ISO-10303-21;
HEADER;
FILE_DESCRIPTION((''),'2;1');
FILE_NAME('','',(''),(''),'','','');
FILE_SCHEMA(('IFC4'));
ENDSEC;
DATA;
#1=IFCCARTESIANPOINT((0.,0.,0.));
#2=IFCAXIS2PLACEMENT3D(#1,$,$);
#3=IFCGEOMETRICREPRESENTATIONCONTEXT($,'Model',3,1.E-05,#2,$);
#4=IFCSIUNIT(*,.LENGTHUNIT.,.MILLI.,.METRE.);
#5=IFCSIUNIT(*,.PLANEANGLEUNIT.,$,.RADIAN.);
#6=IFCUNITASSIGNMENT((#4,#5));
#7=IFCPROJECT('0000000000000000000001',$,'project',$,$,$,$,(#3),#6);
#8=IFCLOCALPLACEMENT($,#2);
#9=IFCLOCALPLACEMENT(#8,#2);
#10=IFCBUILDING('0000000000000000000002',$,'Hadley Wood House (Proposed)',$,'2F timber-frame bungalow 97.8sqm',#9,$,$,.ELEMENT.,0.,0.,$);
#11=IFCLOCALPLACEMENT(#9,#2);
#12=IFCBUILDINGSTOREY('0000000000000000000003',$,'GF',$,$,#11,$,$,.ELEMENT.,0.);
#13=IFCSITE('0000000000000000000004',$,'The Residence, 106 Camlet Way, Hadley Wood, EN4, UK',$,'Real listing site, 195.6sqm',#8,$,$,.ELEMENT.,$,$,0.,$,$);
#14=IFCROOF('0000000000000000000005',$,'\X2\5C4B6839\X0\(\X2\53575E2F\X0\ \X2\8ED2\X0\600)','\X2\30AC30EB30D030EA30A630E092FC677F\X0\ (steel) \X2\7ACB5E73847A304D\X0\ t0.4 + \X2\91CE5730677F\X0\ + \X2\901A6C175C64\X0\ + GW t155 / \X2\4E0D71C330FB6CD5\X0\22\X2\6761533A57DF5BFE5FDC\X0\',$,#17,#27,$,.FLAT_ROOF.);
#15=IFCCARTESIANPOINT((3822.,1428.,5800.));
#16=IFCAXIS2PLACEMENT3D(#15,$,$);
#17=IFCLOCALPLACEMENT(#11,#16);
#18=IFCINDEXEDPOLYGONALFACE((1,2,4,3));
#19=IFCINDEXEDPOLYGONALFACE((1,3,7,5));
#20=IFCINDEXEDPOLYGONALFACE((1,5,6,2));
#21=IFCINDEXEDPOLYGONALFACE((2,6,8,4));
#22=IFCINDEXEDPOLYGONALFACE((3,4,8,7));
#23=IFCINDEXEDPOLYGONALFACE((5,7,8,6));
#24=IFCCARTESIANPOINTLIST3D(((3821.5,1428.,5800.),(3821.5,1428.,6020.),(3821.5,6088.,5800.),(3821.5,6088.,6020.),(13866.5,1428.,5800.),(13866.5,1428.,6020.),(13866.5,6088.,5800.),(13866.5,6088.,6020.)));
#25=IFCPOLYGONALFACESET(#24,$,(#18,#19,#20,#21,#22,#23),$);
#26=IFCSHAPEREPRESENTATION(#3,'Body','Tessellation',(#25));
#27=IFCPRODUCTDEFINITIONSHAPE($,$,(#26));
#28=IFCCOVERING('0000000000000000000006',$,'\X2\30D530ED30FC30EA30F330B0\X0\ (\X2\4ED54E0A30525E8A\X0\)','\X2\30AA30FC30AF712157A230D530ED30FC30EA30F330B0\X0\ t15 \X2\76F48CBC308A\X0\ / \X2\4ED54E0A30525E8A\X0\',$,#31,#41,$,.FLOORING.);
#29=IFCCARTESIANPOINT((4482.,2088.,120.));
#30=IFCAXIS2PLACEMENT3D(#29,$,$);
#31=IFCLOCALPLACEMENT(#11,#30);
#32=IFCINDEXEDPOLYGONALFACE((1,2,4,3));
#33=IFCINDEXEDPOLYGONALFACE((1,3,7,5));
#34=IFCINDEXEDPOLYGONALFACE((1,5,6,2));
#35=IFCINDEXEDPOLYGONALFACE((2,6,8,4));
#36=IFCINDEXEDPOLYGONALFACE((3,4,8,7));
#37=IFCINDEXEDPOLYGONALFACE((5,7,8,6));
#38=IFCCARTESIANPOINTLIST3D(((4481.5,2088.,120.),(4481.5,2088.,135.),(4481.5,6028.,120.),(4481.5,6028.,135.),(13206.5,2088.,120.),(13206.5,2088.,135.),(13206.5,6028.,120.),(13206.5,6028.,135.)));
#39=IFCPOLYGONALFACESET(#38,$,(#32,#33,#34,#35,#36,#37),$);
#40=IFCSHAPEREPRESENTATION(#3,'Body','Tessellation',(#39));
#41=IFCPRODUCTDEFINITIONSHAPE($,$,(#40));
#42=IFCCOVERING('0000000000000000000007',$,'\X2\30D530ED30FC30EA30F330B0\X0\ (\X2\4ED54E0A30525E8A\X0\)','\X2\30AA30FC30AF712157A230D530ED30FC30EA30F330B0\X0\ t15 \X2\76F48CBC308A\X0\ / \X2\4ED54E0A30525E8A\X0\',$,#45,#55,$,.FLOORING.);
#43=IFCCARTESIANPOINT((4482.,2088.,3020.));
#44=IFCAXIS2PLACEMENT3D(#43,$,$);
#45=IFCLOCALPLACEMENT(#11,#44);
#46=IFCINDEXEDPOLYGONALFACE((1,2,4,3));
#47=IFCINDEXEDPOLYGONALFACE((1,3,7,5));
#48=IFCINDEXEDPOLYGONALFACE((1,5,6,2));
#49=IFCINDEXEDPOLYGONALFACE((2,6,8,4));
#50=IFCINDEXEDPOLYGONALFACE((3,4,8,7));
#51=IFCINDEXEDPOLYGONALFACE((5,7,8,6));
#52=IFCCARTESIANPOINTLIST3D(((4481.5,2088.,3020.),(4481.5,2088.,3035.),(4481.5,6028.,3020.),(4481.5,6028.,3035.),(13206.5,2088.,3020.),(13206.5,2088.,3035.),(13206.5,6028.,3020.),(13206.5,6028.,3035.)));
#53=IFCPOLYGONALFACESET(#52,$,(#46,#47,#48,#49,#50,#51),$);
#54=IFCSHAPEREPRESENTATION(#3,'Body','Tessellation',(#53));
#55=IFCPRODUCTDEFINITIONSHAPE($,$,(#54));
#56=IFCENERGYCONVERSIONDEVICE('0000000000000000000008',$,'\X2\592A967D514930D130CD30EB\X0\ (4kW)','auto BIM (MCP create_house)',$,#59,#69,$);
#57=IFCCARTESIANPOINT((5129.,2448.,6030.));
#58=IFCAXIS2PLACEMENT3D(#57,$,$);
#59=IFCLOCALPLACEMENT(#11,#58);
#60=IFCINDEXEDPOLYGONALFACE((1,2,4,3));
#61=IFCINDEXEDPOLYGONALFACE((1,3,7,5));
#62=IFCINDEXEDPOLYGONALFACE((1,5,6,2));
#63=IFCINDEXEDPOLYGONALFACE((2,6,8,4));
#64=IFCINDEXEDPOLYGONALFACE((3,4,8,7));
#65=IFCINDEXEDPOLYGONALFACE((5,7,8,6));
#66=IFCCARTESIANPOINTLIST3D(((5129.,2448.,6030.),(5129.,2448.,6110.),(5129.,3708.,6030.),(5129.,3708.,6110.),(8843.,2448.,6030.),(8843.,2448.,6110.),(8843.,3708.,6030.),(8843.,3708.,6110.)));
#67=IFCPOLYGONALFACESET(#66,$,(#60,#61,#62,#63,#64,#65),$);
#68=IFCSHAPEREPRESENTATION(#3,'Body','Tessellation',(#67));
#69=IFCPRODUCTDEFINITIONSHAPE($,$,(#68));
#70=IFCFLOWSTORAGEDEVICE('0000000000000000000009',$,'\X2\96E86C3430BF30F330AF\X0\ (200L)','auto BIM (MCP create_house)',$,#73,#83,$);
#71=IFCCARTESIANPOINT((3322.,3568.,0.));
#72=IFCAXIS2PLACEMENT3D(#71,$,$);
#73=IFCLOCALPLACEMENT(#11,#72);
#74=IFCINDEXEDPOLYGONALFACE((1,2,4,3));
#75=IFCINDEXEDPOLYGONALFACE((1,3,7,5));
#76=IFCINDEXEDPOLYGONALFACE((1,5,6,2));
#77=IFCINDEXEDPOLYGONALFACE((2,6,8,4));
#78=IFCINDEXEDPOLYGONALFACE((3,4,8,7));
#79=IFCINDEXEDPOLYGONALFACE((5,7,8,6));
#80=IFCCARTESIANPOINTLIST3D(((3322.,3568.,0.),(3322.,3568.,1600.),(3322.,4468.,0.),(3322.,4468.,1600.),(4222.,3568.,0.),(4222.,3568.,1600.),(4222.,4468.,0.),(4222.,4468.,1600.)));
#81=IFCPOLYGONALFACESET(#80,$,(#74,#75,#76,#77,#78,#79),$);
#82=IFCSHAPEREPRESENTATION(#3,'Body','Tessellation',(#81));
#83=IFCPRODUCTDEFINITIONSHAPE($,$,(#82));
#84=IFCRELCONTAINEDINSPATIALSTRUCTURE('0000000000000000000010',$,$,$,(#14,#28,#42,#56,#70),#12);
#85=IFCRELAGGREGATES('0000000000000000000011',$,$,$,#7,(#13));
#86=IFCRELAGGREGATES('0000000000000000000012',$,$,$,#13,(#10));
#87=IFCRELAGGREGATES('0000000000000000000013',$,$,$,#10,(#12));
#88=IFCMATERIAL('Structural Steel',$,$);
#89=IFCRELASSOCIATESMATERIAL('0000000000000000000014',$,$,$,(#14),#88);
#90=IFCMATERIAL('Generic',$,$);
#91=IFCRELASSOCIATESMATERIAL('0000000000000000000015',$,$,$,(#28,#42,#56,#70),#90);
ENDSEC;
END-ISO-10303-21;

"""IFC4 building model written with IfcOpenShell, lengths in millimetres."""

from ifc_helpers import new_model, si_unit, frame, frame_2d, origin, place, context, project, spatial, rectangle, extrude, material, element, save


model = new_model("IFC4")

# Units and contexts
model_context = context("Model", 3, precision=1e-05, world=origin())
ifc_project = project(units=[si_unit("LENGTHUNIT", "METRE", prefix="MILLI"), si_unit("PLANEANGLEUNIT", "RADIAN")], contexts=[model_context])

# Site, building, storey
site_placement = place(None, origin())
site = spatial("IfcSite", under=ifc_project, at=site_placement, Name="The Residence, 106 Camlet Way, Hadley Wood, EN4, UK", ObjectType="Real listing site, 195.6sqm", CompositionType="ELEMENT", RefElevation=0.0)
building_placement = place(site_placement, origin())
building = spatial("IfcBuilding", under=site, at=building_placement, Name="Hadley Wood House (Proposed)", ObjectType="2F timber-frame bungalow 97.8sqm", CompositionType="ELEMENT", ElevationOfRefHeight=0.0, ElevationOfTerrain=0.0)
storey_placement = place(building_placement, origin())
storey = spatial("IfcBuildingStorey", under=building, at=storey_placement, Name="GF", CompositionType="ELEMENT", Elevation=0.0)

# Roof
ifc_material_1 = material(Name="Structural Steel")
for number, where, name in (
    (1, (3822.0, 1428.0, 5800.0), "屋根(南帯 軒600)"),
):
    element("IfcRoof", number, at=place(storey_placement, frame(where)), inside=storey, material=ifc_material_1, Name=name, Description="ガルバリウム鋼板 (steel) 立平葺き t0.4 + 野地板 + 通気層 + GW t155 / 不燃・法22条区域対応", PredefinedType="FLAT_ROOF", context=model_context, shape_type="SweptSolid", body=[
        extrude(rectangle(XDim=10045.0, YDim=4660.0, at=frame_2d((5022.0, 2330.0))), frame((3822.0, 1428.0, 5800.0)), (0.0, 0.0, 1.0), 220.0),
    ])

# Coverings
ifc_material_2 = material(Name="Generic")
covering_1_placement = place(storey_placement, frame((4482.0, 2088.0, 120.0)))
element("IfcCovering", 2, at=covering_1_placement, inside=storey, material=ifc_material_2, Name="フローリング (仕上げ床)", Description="オーク無垢フローリング t15 直貼り / 仕上げ床", PredefinedType="FLOORING", context=model_context, shape_type="SweptSolid", body=[
    extrude(rectangle(XDim=8725.0, YDim=3940.0, at=frame_2d((4362.0, 1970.0))), frame((4482.0, 2088.0, 120.0)), (0.0, 0.0, 1.0), 15.0),
])
covering_2_placement = place(storey_placement, frame((4482.0, 2088.0, 3020.0)))
element("IfcCovering", 3, at=covering_2_placement, inside=storey, material=ifc_material_2, Name="フローリング (仕上げ床)", Description="オーク無垢フローリング t15 直貼り / 仕上げ床", PredefinedType="FLOORING", context=model_context, shape_type="SweptSolid", body=[
    extrude(rectangle(XDim=8725.0, YDim=3940.0, at=frame_2d((4362.0, 1970.0))), frame((4482.0, 2088.0, 3020.0)), (0.0, 0.0, 1.0), 15.0),
])

# Energy conversion device
energy_conversion_device_placement = place(storey_placement, frame((5129.0, 2448.0, 6030.0)))
element("IfcEnergyConversionDevice", 4, at=energy_conversion_device_placement, inside=storey, material=ifc_material_2, Name="太陽光パネル (4kW)", Description="auto BIM (MCP create_house)", context=model_context, shape_type="SweptSolid", body=[
    extrude(rectangle(XDim=3714.0, YDim=1260.0, at=frame_2d((1857.0, 630.0))), frame((5129.0, 2448.0, 6030.0)), (0.0, 0.0, 1.0), 80.0),
])

# Flow storage device
flow_storage_device_placement = place(storey_placement, frame((3322.0, 3568.0, 0.0)))
element("IfcFlowStorageDevice", 5, at=flow_storage_device_placement, inside=storey, material=ifc_material_2, Name="雨水タンク (200L)", Description="auto BIM (MCP create_house)", context=model_context, shape_type="SweptSolid", body=[
    extrude(rectangle(XDim=900.0, YDim=900.0, at=frame_2d((450.0, 450.0))), frame((3322.0, 3568.0, 0.0)), (0.0, 0.0, 1.0), 1600.0),
])

save(model, "model.ifc")
